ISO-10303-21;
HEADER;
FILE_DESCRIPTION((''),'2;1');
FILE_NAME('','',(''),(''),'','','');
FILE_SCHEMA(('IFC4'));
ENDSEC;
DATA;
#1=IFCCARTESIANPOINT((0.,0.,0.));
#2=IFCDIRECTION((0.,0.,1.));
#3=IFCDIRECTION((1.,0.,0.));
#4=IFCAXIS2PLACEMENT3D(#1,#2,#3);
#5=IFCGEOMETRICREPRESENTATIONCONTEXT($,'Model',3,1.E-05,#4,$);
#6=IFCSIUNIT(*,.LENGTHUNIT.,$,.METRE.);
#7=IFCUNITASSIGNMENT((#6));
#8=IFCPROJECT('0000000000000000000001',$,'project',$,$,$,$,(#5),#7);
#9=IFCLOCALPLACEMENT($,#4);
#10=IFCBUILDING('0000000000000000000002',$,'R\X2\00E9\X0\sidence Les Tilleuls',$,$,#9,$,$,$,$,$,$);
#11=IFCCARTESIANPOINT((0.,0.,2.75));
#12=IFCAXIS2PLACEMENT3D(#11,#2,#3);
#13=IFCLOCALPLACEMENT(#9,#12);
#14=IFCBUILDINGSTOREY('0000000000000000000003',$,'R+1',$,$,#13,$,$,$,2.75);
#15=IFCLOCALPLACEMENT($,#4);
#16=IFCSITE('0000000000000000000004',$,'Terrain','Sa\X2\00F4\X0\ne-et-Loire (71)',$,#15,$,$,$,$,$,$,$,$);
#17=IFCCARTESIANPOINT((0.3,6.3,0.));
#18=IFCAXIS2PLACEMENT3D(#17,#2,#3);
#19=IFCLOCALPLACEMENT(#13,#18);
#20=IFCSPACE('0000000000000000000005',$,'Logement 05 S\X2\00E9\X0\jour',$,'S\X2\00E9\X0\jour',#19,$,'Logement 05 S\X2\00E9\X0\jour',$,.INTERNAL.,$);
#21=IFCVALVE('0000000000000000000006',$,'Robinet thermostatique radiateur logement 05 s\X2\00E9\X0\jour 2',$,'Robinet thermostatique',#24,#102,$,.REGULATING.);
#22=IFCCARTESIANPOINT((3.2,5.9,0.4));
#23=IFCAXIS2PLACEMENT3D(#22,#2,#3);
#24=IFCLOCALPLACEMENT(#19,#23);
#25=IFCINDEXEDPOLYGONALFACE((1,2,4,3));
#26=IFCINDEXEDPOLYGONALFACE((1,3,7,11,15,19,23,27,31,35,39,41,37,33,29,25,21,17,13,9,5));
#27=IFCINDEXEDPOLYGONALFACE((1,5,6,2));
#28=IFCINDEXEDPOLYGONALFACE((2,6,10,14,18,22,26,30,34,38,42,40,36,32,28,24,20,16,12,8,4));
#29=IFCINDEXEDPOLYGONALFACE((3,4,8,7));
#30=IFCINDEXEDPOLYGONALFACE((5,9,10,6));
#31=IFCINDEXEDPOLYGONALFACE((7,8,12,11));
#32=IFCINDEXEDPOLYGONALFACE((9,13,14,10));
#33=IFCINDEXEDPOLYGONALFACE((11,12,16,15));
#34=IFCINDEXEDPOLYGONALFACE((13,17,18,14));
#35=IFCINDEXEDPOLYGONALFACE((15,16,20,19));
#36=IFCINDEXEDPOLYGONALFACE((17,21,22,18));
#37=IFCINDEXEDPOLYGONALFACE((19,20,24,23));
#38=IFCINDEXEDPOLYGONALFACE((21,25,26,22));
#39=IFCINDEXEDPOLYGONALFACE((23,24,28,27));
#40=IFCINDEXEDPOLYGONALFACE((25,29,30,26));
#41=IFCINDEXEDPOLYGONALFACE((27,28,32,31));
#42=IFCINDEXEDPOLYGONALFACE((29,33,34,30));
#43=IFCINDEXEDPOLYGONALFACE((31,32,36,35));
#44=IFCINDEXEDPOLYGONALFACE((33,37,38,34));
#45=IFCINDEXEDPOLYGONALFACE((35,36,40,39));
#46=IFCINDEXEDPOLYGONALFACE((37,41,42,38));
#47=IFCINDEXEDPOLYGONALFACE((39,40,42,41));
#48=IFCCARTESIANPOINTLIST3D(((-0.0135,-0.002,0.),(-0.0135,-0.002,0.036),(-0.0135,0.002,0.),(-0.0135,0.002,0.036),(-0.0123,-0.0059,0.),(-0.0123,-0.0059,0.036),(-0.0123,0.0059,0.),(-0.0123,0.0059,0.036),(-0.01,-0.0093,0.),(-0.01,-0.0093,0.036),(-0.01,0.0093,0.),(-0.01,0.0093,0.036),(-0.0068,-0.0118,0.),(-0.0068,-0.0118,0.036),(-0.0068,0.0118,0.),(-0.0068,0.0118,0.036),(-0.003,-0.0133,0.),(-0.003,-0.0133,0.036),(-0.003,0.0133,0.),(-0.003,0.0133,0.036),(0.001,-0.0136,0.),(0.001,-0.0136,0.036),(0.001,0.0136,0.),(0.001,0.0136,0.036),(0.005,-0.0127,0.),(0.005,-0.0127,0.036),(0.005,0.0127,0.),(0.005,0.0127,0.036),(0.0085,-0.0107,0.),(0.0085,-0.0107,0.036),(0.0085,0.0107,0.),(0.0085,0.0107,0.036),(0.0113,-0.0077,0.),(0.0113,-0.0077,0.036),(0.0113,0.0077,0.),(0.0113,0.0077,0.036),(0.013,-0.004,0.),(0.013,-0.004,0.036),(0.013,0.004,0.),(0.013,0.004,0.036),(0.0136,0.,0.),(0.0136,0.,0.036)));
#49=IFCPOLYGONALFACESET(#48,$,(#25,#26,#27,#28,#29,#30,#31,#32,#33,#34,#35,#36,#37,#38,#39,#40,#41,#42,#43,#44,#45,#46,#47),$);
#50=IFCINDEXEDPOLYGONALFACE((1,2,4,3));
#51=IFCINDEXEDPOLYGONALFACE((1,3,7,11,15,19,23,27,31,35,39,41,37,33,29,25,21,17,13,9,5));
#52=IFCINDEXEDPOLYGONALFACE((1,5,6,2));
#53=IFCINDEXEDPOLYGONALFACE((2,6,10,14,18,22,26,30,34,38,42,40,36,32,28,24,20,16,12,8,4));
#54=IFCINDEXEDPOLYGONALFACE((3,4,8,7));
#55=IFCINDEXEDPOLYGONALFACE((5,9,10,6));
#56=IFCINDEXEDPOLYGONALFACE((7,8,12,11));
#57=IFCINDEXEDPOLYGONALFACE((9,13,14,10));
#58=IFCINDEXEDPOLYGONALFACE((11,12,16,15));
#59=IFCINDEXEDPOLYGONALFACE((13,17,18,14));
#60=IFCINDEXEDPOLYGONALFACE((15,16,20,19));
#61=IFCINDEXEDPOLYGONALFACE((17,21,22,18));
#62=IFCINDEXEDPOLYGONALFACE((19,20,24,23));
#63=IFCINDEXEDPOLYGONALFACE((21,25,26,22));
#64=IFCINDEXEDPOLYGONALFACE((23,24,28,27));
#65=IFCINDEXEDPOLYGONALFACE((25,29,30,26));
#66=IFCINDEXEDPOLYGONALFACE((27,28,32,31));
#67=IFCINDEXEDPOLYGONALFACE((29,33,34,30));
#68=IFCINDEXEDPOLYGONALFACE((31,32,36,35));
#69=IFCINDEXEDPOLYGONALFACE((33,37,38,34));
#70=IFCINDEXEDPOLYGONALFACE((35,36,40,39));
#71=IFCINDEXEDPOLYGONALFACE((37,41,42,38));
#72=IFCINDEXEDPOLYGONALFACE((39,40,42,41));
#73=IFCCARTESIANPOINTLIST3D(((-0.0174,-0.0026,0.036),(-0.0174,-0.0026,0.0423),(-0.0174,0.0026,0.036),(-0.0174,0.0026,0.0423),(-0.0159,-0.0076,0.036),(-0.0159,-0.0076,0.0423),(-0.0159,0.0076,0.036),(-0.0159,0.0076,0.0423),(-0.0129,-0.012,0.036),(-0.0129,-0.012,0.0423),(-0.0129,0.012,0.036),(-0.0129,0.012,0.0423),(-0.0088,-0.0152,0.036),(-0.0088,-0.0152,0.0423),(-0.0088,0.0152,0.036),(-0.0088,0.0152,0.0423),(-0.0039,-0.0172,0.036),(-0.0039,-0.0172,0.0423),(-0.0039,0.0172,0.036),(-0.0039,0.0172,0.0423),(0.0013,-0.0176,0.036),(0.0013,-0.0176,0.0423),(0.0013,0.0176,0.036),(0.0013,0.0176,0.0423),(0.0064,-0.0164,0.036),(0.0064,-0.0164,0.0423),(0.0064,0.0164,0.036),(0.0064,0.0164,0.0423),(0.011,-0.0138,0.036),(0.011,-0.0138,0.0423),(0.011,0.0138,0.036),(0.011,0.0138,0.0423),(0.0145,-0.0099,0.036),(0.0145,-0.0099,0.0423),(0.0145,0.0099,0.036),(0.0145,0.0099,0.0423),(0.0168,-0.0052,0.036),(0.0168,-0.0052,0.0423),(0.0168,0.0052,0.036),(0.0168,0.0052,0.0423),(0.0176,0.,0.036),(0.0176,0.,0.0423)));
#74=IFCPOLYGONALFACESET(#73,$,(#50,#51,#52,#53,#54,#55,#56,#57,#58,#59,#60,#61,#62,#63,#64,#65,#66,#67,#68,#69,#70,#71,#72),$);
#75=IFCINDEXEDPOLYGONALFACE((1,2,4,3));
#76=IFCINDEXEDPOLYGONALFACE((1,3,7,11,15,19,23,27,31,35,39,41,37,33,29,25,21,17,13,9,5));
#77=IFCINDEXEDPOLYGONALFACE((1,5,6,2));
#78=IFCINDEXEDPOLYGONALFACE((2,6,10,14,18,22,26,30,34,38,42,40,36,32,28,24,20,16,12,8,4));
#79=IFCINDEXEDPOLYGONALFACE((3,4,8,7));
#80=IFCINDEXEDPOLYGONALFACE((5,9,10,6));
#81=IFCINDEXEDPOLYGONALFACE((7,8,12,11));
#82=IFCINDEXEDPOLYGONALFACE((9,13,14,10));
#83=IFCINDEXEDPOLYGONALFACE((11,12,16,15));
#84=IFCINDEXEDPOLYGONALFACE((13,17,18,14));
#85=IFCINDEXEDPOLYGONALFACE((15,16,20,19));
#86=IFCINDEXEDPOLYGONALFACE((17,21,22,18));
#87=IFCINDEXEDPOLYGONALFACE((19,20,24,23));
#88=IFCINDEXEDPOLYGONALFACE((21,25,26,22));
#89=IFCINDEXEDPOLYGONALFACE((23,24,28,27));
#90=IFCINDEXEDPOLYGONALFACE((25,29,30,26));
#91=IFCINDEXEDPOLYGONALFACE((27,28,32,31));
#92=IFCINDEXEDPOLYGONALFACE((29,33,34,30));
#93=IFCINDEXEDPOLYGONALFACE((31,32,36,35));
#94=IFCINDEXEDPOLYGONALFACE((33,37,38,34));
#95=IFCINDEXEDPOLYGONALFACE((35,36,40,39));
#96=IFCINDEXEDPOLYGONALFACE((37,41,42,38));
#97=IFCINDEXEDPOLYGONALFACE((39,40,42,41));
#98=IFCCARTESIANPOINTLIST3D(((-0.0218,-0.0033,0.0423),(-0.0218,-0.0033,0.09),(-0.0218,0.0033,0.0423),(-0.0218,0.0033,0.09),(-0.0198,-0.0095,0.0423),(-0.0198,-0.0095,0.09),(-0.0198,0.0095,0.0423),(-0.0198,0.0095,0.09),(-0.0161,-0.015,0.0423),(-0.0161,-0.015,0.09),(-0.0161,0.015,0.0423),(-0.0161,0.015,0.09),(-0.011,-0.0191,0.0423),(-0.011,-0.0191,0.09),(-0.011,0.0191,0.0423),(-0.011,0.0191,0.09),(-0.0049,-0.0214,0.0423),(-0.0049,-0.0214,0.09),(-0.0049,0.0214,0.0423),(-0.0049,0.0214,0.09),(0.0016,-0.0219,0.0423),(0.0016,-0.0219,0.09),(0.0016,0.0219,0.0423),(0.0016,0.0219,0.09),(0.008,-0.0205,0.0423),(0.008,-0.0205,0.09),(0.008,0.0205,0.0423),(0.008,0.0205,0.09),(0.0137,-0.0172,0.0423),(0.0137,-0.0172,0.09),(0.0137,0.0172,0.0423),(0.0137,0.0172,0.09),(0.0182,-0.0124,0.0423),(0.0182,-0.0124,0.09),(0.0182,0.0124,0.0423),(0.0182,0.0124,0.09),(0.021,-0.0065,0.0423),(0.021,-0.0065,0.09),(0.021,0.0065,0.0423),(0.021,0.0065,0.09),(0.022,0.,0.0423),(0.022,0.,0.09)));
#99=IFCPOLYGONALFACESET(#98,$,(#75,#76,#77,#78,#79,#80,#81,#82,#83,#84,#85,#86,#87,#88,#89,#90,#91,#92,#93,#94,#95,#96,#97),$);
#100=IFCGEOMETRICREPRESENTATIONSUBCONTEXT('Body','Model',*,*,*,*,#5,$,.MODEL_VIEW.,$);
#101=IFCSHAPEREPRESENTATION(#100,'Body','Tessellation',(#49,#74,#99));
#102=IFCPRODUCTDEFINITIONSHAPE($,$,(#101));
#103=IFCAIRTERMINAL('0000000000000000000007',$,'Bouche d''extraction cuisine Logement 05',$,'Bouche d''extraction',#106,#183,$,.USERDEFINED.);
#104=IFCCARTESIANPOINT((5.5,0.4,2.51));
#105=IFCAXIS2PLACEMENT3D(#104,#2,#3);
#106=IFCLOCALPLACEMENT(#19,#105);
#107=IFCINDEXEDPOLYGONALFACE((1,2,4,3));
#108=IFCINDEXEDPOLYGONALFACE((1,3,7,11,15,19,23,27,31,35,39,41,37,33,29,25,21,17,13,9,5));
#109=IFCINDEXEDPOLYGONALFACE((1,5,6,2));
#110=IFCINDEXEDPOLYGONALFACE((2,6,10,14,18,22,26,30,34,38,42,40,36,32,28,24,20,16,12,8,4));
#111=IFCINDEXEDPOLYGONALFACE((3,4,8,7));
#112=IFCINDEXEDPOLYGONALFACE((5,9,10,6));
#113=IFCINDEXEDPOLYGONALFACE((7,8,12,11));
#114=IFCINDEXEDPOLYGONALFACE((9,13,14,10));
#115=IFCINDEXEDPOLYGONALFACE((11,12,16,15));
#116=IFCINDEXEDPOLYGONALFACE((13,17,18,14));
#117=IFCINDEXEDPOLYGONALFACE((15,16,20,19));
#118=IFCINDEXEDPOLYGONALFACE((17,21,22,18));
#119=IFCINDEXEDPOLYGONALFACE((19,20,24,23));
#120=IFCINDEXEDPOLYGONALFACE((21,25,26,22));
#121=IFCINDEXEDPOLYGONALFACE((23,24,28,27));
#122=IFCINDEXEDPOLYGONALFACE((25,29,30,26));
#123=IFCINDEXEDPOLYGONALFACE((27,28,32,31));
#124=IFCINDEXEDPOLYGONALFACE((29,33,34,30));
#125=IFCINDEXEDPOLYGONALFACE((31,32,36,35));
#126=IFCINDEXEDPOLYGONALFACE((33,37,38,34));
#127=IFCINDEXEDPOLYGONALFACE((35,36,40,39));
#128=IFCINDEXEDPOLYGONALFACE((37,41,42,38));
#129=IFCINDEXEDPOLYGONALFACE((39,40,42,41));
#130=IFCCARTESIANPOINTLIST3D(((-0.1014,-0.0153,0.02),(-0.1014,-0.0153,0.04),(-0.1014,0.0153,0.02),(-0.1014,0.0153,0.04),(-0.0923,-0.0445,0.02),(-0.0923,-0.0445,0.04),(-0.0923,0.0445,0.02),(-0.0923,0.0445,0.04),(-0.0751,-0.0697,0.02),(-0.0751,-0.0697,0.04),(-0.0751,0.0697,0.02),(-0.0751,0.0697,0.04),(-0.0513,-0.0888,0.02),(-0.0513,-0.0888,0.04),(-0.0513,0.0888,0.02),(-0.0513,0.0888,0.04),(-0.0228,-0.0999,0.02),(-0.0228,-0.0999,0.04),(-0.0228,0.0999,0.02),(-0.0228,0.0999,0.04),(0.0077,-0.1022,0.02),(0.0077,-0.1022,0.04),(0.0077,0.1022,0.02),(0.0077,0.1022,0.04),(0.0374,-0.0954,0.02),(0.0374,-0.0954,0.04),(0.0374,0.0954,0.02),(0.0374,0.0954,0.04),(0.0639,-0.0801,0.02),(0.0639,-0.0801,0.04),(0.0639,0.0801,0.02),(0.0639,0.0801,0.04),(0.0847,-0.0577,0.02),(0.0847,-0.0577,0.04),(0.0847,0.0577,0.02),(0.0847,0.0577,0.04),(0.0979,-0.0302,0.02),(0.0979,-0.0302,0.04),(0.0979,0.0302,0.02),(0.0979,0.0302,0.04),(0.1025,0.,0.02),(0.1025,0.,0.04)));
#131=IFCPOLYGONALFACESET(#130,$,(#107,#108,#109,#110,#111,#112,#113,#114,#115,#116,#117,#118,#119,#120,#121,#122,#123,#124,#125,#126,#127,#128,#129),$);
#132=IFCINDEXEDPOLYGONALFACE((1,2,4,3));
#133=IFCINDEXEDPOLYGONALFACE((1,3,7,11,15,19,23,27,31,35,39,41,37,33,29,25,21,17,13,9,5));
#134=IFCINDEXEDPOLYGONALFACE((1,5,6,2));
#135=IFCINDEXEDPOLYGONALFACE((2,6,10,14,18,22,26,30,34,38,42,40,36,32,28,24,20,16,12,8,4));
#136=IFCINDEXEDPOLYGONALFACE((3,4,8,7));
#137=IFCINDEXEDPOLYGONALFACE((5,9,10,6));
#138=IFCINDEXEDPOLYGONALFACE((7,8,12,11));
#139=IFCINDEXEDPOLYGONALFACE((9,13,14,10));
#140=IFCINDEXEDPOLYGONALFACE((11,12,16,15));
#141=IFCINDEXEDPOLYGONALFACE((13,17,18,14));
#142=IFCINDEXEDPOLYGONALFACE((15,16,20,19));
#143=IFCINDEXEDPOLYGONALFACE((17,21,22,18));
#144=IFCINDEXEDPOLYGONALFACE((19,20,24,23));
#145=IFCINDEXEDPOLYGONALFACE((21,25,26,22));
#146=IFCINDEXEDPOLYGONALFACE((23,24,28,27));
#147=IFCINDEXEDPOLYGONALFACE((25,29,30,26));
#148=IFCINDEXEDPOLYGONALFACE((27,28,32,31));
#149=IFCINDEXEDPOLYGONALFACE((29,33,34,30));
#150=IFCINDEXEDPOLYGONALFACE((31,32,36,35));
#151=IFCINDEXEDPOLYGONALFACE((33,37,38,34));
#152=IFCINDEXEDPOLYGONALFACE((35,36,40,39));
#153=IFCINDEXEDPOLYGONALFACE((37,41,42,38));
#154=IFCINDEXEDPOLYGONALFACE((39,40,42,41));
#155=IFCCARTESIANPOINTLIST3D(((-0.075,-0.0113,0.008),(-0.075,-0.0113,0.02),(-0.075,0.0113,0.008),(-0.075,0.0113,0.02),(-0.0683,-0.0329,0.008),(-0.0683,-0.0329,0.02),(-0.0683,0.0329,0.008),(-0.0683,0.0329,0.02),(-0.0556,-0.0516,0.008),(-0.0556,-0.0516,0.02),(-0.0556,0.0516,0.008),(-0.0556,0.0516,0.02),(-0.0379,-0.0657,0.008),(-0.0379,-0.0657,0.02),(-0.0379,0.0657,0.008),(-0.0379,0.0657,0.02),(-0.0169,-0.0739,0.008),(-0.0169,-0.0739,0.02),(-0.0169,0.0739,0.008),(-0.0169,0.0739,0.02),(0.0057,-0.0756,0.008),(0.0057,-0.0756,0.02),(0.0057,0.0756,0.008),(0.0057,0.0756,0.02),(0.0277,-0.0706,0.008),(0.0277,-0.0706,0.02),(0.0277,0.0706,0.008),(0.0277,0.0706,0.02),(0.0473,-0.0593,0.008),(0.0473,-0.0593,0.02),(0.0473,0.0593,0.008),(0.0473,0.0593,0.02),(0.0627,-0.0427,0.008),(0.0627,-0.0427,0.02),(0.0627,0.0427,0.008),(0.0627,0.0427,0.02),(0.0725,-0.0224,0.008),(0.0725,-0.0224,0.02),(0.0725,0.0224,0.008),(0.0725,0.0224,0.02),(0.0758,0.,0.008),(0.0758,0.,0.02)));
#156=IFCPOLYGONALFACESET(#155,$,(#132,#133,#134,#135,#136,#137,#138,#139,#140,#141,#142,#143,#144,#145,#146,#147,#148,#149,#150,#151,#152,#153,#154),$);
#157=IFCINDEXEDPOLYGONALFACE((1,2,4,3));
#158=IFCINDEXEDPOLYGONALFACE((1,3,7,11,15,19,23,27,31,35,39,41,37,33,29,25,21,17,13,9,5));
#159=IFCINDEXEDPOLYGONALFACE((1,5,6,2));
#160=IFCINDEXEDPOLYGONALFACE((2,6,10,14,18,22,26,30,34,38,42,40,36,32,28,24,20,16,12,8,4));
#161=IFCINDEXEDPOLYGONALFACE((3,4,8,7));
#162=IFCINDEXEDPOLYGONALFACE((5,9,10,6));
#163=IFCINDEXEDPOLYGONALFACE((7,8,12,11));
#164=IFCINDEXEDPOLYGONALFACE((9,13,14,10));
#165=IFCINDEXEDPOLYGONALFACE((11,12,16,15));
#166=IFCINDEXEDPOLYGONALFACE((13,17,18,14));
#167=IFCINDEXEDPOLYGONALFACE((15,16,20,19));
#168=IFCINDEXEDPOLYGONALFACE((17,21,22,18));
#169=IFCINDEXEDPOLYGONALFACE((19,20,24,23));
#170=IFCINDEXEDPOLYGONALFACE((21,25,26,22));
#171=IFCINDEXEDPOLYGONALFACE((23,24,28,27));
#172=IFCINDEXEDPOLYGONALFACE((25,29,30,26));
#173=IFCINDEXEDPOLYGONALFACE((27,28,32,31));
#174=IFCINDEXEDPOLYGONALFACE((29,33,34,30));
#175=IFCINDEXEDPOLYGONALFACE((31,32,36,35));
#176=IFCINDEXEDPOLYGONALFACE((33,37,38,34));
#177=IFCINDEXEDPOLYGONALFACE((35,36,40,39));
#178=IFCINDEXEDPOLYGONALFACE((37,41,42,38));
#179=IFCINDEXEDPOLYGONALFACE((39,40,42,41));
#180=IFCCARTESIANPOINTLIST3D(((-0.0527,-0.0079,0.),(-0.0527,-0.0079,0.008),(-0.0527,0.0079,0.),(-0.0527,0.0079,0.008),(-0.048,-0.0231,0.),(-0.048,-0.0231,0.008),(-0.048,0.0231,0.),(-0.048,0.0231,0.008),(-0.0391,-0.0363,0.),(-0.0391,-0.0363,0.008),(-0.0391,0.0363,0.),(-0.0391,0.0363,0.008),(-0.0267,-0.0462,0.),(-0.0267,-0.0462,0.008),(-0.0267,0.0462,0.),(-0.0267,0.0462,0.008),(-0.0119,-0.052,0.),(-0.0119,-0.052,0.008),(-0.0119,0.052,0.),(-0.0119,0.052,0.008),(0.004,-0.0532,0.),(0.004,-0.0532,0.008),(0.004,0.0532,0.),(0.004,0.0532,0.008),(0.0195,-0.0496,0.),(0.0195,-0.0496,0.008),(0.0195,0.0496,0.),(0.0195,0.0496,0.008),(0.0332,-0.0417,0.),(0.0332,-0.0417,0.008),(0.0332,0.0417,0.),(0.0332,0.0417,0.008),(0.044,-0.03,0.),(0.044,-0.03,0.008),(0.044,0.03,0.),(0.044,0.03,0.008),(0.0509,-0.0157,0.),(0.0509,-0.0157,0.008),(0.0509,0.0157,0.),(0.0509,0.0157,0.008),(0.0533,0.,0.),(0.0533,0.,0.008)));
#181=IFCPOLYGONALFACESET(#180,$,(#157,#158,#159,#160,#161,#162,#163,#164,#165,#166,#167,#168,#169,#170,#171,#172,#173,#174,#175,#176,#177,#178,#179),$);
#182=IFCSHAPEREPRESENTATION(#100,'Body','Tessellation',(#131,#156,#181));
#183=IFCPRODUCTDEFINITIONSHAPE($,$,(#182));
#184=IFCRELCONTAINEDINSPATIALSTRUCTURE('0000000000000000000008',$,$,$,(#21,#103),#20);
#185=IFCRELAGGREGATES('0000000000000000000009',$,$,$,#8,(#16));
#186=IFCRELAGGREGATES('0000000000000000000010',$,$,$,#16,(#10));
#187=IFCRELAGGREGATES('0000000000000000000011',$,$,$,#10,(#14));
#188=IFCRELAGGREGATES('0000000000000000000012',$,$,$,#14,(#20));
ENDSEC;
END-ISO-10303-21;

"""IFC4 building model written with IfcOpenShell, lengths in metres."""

from ifc_helpers import new_model, si_unit, frame, origin_with_axes, place, context, subcontext, project, spatial, circle, extrude, element, save


model = new_model("IFC4")

# Units and contexts
model_context = context("Model", 3, precision=1e-05, world=origin_with_axes())
body_context = subcontext(model_context, "Body", "Model", "MODEL_VIEW")
ifc_project = project(units=[si_unit("LENGTHUNIT", "METRE")], contexts=[model_context])

# Site, building, storey
site_placement = place(None, origin_with_axes())
site = spatial("IfcSite", under=ifc_project, at=site_placement, Name="Terrain", Description="Saône-et-Loire (71)")
building_placement = place(None, origin_with_axes())
building = spatial("IfcBuilding", under=site, at=building_placement, Name="Résidence Les Tilleuls")
storey_placement = place(building_placement, frame((0.0, 0.0, 2.75), z_axis=(0.0, 0.0, 1.0), x_axis=(1.0, 0.0, 0.0)))
storey = spatial("IfcBuildingStorey", under=building, at=storey_placement, Name="R+1", Elevation=2.75)

# Shared definitions
space_placement = place(storey_placement, frame((0.3, 6.3, 0.0), z_axis=(0.0, 0.0, 1.0), x_axis=(1.0, 0.0, 0.0)))
space = spatial("IfcSpace", under=storey, at=space_placement, Name="Logement 05 Séjour", ObjectType="Séjour", LongName="Logement 05 Séjour", PredefinedType="INTERNAL")

# Valve
valve_placement = place(space_placement, frame((3.2, 5.9, 0.4), z_axis=(0.0, 0.0, 1.0), x_axis=(1.0, 0.0, 0.0)))
element("IfcValve", 1, at=valve_placement, inside=space, Name="Robinet thermostatique radiateur logement 05 séjour 2", ObjectType="Robinet thermostatique", PredefinedType="REGULATING", context=body_context, shape_type="SweptSolid", body=[
    extrude(circle(Radius=0.0136), origin_with_axes(), (0.0, 0.0, 1.0), 0.036),
    extrude(circle(Radius=0.0176), frame((0.0, 0.0, 0.036), z_axis=(0.0, 0.0, 1.0), x_axis=(1.0, 0.0, 0.0)), (0.0, 0.0, 1.0), 0.0063),
    extrude(circle(Radius=0.022), frame((0.0, 0.0, 0.0423), z_axis=(0.0, 0.0, 1.0), x_axis=(1.0, 0.0, 0.0)), (0.0, 0.0, 1.0), 0.0477),
])

# Air terminal
air_terminal_placement = place(space_placement, frame((5.5, 0.4, 2.51), z_axis=(0.0, 0.0, 1.0), x_axis=(1.0, 0.0, 0.0)))
element("IfcAirTerminal", 2, at=air_terminal_placement, inside=space, Name="Bouche d'extraction cuisine Logement 05", ObjectType="Bouche d'extraction", PredefinedType="USERDEFINED", context=body_context, shape_type="SweptSolid", body=[
    extrude(circle(Radius=0.1025), frame((0.0, 0.0, 0.02), z_axis=(0.0, 0.0, 1.0), x_axis=(1.0, 0.0, 0.0)), (0.0, 0.0, 1.0), 0.02),
    extrude(circle(Radius=0.0759), frame((0.0, 0.0, 0.008), z_axis=(0.0, 0.0, 1.0), x_axis=(1.0, 0.0, 0.0)), (0.0, 0.0, 1.0), 0.012),
    extrude(circle(Radius=0.0533), origin_with_axes(), (0.0, 0.0, 1.0), 0.008),
])

save(model, "model.ifc")
